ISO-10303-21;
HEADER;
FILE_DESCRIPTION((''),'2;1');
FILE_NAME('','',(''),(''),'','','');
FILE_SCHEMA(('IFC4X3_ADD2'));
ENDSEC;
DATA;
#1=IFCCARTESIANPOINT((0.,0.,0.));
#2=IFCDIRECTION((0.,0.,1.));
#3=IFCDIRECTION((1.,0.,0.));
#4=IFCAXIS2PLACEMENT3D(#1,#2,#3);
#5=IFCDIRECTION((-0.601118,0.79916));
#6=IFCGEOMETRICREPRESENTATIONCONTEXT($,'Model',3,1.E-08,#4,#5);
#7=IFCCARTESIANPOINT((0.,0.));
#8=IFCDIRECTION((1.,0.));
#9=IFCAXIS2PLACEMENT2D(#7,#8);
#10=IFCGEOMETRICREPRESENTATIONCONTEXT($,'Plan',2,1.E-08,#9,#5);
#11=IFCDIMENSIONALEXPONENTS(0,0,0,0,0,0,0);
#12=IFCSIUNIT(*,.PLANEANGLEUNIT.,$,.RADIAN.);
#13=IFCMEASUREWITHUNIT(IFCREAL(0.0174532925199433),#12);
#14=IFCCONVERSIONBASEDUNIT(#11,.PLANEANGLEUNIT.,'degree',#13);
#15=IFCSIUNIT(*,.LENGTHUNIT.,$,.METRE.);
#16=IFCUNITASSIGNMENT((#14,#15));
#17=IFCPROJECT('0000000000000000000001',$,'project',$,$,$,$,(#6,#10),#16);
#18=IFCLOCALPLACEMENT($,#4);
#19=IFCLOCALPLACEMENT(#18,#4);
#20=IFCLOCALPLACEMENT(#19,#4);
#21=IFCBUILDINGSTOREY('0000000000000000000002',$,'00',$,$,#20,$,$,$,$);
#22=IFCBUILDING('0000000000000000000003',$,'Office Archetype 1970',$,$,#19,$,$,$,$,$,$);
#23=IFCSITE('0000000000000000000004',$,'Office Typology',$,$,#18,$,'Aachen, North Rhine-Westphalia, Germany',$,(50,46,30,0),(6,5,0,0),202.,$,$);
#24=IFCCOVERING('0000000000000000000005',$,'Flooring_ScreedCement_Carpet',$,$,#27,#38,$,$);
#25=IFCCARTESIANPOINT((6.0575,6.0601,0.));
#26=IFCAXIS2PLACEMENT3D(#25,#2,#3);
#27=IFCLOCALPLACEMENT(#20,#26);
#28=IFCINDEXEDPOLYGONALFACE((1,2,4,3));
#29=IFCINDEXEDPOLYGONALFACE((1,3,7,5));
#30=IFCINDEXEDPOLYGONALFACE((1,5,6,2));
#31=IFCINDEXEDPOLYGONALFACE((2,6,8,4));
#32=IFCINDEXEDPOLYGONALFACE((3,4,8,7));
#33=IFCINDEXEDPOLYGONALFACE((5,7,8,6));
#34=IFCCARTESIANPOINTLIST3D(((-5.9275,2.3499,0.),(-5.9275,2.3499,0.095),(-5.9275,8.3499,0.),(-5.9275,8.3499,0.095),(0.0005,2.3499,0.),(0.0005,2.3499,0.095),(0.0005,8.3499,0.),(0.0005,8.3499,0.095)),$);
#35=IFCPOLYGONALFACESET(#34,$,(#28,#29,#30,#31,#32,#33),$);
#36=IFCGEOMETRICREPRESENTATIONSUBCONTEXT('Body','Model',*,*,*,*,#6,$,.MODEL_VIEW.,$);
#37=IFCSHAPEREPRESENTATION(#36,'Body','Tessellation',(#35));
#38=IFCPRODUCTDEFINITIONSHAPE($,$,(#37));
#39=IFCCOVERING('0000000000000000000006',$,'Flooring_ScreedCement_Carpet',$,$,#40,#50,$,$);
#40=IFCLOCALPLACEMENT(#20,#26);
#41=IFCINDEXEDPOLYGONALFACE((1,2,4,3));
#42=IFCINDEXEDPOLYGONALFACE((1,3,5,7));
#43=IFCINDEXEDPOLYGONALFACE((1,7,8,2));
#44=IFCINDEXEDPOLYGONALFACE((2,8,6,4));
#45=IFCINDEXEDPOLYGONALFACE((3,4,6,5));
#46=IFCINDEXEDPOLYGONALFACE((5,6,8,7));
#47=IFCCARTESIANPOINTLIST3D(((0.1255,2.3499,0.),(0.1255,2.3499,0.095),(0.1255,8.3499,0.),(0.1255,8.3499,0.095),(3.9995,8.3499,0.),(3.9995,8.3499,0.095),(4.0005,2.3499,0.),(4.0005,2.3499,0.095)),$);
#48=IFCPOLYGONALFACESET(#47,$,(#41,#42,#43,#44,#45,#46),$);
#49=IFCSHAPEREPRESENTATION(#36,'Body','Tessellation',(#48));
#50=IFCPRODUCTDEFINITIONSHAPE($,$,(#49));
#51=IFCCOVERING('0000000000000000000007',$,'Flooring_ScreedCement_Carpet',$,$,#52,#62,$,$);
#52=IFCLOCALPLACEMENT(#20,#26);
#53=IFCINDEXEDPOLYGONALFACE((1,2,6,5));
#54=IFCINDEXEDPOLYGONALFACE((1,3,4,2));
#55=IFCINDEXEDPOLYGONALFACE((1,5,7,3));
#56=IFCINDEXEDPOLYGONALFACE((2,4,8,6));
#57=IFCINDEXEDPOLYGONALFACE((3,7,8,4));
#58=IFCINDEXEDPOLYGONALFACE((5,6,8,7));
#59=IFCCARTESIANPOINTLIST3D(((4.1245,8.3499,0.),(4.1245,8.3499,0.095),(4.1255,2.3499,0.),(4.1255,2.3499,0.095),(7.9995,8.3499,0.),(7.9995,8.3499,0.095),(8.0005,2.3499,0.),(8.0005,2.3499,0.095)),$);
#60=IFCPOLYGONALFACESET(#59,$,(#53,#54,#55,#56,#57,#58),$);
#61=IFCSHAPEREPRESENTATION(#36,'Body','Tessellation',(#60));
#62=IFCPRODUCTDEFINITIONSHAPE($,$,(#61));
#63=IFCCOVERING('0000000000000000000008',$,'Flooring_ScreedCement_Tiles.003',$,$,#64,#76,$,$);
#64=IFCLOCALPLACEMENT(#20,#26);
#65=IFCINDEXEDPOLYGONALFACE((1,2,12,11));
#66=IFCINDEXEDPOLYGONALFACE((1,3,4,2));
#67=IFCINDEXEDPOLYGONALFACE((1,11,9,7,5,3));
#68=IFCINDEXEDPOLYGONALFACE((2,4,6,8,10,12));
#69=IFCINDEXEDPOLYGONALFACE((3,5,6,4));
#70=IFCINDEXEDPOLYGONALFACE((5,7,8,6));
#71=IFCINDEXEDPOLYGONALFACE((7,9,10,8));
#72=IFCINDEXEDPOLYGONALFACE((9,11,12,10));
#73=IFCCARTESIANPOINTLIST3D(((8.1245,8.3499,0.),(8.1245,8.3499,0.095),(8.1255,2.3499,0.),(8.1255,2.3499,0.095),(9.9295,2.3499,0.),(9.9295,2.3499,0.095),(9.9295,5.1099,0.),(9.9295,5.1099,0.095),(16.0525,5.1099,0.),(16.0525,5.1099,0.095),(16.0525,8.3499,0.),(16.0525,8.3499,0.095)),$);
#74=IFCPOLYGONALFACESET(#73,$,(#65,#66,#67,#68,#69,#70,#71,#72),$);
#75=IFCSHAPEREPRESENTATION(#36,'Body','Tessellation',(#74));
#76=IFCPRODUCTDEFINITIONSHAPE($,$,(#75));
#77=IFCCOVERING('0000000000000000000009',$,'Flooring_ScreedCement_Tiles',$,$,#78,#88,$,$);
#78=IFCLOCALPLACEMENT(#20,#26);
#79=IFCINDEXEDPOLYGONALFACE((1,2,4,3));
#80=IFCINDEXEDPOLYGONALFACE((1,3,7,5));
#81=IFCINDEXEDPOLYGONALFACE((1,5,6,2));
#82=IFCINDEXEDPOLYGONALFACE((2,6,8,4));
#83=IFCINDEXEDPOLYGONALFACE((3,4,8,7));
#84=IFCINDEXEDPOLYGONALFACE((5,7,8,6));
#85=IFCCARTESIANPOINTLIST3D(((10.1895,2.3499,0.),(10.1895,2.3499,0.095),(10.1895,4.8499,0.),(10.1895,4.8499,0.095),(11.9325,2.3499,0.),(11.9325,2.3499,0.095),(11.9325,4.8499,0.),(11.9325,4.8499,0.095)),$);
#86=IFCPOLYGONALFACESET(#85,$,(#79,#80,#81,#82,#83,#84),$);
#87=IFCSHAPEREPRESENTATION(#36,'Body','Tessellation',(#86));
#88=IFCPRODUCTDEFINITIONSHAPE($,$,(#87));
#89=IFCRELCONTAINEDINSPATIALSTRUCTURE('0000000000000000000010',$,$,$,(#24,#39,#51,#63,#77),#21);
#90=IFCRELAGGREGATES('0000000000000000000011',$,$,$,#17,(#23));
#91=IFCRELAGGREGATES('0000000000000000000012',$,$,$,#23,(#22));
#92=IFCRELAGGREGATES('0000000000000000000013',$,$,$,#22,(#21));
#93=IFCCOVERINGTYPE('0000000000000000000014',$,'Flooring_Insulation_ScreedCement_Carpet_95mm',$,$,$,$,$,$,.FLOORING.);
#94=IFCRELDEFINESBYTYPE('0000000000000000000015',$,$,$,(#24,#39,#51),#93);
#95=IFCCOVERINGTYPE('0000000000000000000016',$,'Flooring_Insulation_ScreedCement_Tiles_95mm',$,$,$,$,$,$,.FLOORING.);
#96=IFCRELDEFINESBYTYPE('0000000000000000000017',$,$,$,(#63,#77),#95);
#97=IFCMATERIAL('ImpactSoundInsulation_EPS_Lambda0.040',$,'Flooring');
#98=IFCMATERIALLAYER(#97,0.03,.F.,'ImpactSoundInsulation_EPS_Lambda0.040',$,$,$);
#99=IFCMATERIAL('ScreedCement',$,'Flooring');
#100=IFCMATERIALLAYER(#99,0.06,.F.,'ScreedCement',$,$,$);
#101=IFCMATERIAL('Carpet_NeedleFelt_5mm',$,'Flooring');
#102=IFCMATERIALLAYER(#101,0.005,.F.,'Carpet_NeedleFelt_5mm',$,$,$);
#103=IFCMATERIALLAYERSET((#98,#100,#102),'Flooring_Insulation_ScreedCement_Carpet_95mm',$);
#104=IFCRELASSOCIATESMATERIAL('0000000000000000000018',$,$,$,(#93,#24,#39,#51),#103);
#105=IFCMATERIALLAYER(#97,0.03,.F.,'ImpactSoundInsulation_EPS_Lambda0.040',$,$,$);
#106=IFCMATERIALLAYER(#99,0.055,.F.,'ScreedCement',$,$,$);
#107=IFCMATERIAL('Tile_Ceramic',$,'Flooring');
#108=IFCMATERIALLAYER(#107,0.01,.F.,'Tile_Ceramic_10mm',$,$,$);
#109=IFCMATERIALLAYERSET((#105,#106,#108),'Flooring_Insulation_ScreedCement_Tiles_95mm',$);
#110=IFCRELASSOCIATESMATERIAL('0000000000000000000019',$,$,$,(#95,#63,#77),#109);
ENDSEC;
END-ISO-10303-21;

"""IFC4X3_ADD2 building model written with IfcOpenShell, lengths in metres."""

from ifc_helpers import new_model, entity, si_unit, converted_unit, direction, frame, origin_with_axes, origin_2d_with_axis, place, context, subcontext, project, spatial, line, indexed_curve, outline, extrude, material, layer, layer_set, layer_usage, type_object, element, save


model = new_model("IFC4X3_ADD2")

# Units and contexts
model_context = context("Model", 3, precision=1e-08, world=origin_with_axes(), true_north=direction((-0.601118, 0.79916)))
plan_context = context("Plan", 2, precision=1e-08, world=origin_2d_with_axis(), true_north=direction((-0.601118, 0.79916)))
body_context = subcontext(model_context, "Body", "Model", "MODEL_VIEW")
ifc_project = project(units=[converted_unit("PLANEANGLEUNIT", "degree", entity("IfcReal", 0.0174532925199433), si_unit("PLANEANGLEUNIT", "RADIAN"), dimensions=[0, 0, 0, 0, 0, 0, 0]), si_unit("LENGTHUNIT", "METRE")], contexts=[model_context, plan_context])

# Site, building, storey
site_placement = place(None, origin_with_axes())
site = spatial("IfcSite", under=ifc_project, at=site_placement, Name="Office Typology", LongName="Aachen, North Rhine-Westphalia, Germany", RefLatitude=(50, 46, 30, 0), RefLongitude=(6, 5, 0, 0), RefElevation=202.0)
building_placement = place(site_placement, origin_with_axes())
building = spatial("IfcBuilding", under=site, at=building_placement, Name="Office Archetype 1970")
storey_placement = place(building_placement, origin_with_axes())
storey = spatial("IfcBuildingStorey", under=building, at=storey_placement, Name="00")

# Coverings
ifc_material_1 = material(Name="ImpactSoundInsulation_EPS_Lambda0.040", Category="Flooring")
ifc_layer_1 = layer(ifc_material_1, 0.03, ventilated=False, Name="ImpactSoundInsulation_EPS_Lambda0.040")
ifc_material_2 = material(Name="ScreedCement", Category="Flooring")
ifc_layer_2 = layer(ifc_material_2, 0.06, ventilated=False, Name="ScreedCement")
ifc_material_3 = material(Name="Carpet_NeedleFelt_5mm", Category="Flooring")
ifc_layer_3 = layer(ifc_material_3, 0.005, ventilated=False, Name="Carpet_NeedleFelt_5mm")
ifc_layer_set_1 = layer_set([ifc_layer_1, ifc_layer_2, ifc_layer_3], Name="Flooring_Insulation_ScreedCement_Carpet_95mm")
ifc_layer_usage_1 = layer_usage(ifc_layer_set_1, "AXIS3", "POSITIVE", 0.0)
covering_type_1 = type_object("IfcCoveringType", Name="Flooring_Insulation_ScreedCement_Carpet_95mm", PredefinedType="FLOORING", material=ifc_layer_set_1)
covering_1_placement = place(storey_placement, frame((6.0575, 6.0601, 0.0), z_axis=(0.0, 0.0, 1.0), x_axis=(1.0, 0.0, 0.0)))
element("IfcCovering", 1, at=covering_1_placement, inside=storey, type_object=covering_type_1, material=ifc_layer_usage_1, Name="Flooring_ScreedCement_Carpet", context=body_context, shape_type="SweptSolid", body=[
    extrude(outline(indexed_curve([(-5.9275, 2.3499), (-5.9275, 8.3499), (0.0005, 8.3499), (0.0005, 2.3499)], segments=[line(1, 2, 3, 4, 1)])), origin_with_axes(), (0.0, 0.0, 1.0), 0.095),
])
ifc_layer_usage_2 = layer_usage(ifc_layer_set_1, "AXIS3", "POSITIVE", 0.0)
covering_2_placement = place(storey_placement, frame((6.0575, 6.0601, 0.0), z_axis=(0.0, 0.0, 1.0), x_axis=(1.0, 0.0, 0.0)))
element("IfcCovering", 2, at=covering_2_placement, inside=storey, type_object=covering_type_1, material=ifc_layer_usage_2, Name="Flooring_ScreedCement_Carpet", context=body_context, shape_type="SweptSolid", body=[
    extrude(outline(indexed_curve([(0.1255, 2.3499), (0.1255, 8.3499), (3.9995, 8.3499), (4.0005, 2.3499)], segments=[line(1, 2, 3, 4, 1)])), origin_with_axes(), (0.0, 0.0, 1.0), 0.095),
])
ifc_layer_usage_3 = layer_usage(ifc_layer_set_1, "AXIS3", "POSITIVE", 0.0)
covering_3_placement = place(storey_placement, frame((6.0575, 6.0601, 0.0), z_axis=(0.0, 0.0, 1.0), x_axis=(1.0, 0.0, 0.0)))
element("IfcCovering", 3, at=covering_3_placement, inside=storey, type_object=covering_type_1, material=ifc_layer_usage_3, Name="Flooring_ScreedCement_Carpet", context=body_context, shape_type="SweptSolid", body=[
    extrude(outline(indexed_curve([(4.1255, 2.3499), (4.1245, 8.3499), (7.9995, 8.3499), (8.0005, 2.3499)], segments=[line(1, 2, 3, 4, 1)])), origin_with_axes(), (0.0, 0.0, 1.0), 0.095),
])
ifc_layer_4 = layer(ifc_material_1, 0.03, ventilated=False, Name="ImpactSoundInsulation_EPS_Lambda0.040")
ifc_layer_5 = layer(ifc_material_2, 0.055, ventilated=False, Name="ScreedCement")
ifc_material_4 = material(Name="Tile_Ceramic", Category="Flooring")
ifc_layer_6 = layer(ifc_material_4, 0.01, ventilated=False, Name="Tile_Ceramic_10mm")
ifc_layer_set_2 = layer_set([ifc_layer_4, ifc_layer_5, ifc_layer_6], Name="Flooring_Insulation_ScreedCement_Tiles_95mm")
ifc_layer_usage_4 = layer_usage(ifc_layer_set_2, "AXIS3", "POSITIVE", 0.0)
covering_type_2 = type_object("IfcCoveringType", Name="Flooring_Insulation_ScreedCement_Tiles_95mm", PredefinedType="FLOORING", material=ifc_layer_set_2)
covering_4_placement = place(storey_placement, frame((6.0575, 6.0601, 0.0), z_axis=(0.0, 0.0, 1.0), x_axis=(1.0, 0.0, 0.0)))
element("IfcCovering", 4, at=covering_4_placement, inside=storey, type_object=covering_type_2, material=ifc_layer_usage_4, Name="Flooring_ScreedCement_Tiles.003", context=body_context, shape_type="SweptSolid", body=[
    extrude(outline(indexed_curve([(9.9295, 2.3499), (8.1255, 2.3499), (8.1245, 8.3499), (16.0525, 8.3499), (16.0525, 5.1099), (9.9295, 5.1099)], segments=[line(1, 2, 3, 4, 5, 6, 1)])), None, (0.0, 0.0, 1.0), 0.095),
])
ifc_layer_usage_5 = layer_usage(ifc_layer_set_2, "AXIS3", "POSITIVE", 0.0)
covering_5_placement = place(storey_placement, frame((6.0575, 6.0601, 0.0), z_axis=(0.0, 0.0, 1.0), x_axis=(1.0, 0.0, 0.0)))
element("IfcCovering", 5, at=covering_5_placement, inside=storey, type_object=covering_type_2, material=ifc_layer_usage_5, Name="Flooring_ScreedCement_Tiles", context=body_context, shape_type="SweptSolid", body=[
    extrude(outline(indexed_curve([(10.1895, 4.8499), (10.1895, 2.3499), (11.9325, 2.3499), (11.9325, 4.8499), (10.1895, 4.8499)])), origin_with_axes(), (0.0, 0.0, 1.0), 0.095),
])

save(model, "model.ifc")
